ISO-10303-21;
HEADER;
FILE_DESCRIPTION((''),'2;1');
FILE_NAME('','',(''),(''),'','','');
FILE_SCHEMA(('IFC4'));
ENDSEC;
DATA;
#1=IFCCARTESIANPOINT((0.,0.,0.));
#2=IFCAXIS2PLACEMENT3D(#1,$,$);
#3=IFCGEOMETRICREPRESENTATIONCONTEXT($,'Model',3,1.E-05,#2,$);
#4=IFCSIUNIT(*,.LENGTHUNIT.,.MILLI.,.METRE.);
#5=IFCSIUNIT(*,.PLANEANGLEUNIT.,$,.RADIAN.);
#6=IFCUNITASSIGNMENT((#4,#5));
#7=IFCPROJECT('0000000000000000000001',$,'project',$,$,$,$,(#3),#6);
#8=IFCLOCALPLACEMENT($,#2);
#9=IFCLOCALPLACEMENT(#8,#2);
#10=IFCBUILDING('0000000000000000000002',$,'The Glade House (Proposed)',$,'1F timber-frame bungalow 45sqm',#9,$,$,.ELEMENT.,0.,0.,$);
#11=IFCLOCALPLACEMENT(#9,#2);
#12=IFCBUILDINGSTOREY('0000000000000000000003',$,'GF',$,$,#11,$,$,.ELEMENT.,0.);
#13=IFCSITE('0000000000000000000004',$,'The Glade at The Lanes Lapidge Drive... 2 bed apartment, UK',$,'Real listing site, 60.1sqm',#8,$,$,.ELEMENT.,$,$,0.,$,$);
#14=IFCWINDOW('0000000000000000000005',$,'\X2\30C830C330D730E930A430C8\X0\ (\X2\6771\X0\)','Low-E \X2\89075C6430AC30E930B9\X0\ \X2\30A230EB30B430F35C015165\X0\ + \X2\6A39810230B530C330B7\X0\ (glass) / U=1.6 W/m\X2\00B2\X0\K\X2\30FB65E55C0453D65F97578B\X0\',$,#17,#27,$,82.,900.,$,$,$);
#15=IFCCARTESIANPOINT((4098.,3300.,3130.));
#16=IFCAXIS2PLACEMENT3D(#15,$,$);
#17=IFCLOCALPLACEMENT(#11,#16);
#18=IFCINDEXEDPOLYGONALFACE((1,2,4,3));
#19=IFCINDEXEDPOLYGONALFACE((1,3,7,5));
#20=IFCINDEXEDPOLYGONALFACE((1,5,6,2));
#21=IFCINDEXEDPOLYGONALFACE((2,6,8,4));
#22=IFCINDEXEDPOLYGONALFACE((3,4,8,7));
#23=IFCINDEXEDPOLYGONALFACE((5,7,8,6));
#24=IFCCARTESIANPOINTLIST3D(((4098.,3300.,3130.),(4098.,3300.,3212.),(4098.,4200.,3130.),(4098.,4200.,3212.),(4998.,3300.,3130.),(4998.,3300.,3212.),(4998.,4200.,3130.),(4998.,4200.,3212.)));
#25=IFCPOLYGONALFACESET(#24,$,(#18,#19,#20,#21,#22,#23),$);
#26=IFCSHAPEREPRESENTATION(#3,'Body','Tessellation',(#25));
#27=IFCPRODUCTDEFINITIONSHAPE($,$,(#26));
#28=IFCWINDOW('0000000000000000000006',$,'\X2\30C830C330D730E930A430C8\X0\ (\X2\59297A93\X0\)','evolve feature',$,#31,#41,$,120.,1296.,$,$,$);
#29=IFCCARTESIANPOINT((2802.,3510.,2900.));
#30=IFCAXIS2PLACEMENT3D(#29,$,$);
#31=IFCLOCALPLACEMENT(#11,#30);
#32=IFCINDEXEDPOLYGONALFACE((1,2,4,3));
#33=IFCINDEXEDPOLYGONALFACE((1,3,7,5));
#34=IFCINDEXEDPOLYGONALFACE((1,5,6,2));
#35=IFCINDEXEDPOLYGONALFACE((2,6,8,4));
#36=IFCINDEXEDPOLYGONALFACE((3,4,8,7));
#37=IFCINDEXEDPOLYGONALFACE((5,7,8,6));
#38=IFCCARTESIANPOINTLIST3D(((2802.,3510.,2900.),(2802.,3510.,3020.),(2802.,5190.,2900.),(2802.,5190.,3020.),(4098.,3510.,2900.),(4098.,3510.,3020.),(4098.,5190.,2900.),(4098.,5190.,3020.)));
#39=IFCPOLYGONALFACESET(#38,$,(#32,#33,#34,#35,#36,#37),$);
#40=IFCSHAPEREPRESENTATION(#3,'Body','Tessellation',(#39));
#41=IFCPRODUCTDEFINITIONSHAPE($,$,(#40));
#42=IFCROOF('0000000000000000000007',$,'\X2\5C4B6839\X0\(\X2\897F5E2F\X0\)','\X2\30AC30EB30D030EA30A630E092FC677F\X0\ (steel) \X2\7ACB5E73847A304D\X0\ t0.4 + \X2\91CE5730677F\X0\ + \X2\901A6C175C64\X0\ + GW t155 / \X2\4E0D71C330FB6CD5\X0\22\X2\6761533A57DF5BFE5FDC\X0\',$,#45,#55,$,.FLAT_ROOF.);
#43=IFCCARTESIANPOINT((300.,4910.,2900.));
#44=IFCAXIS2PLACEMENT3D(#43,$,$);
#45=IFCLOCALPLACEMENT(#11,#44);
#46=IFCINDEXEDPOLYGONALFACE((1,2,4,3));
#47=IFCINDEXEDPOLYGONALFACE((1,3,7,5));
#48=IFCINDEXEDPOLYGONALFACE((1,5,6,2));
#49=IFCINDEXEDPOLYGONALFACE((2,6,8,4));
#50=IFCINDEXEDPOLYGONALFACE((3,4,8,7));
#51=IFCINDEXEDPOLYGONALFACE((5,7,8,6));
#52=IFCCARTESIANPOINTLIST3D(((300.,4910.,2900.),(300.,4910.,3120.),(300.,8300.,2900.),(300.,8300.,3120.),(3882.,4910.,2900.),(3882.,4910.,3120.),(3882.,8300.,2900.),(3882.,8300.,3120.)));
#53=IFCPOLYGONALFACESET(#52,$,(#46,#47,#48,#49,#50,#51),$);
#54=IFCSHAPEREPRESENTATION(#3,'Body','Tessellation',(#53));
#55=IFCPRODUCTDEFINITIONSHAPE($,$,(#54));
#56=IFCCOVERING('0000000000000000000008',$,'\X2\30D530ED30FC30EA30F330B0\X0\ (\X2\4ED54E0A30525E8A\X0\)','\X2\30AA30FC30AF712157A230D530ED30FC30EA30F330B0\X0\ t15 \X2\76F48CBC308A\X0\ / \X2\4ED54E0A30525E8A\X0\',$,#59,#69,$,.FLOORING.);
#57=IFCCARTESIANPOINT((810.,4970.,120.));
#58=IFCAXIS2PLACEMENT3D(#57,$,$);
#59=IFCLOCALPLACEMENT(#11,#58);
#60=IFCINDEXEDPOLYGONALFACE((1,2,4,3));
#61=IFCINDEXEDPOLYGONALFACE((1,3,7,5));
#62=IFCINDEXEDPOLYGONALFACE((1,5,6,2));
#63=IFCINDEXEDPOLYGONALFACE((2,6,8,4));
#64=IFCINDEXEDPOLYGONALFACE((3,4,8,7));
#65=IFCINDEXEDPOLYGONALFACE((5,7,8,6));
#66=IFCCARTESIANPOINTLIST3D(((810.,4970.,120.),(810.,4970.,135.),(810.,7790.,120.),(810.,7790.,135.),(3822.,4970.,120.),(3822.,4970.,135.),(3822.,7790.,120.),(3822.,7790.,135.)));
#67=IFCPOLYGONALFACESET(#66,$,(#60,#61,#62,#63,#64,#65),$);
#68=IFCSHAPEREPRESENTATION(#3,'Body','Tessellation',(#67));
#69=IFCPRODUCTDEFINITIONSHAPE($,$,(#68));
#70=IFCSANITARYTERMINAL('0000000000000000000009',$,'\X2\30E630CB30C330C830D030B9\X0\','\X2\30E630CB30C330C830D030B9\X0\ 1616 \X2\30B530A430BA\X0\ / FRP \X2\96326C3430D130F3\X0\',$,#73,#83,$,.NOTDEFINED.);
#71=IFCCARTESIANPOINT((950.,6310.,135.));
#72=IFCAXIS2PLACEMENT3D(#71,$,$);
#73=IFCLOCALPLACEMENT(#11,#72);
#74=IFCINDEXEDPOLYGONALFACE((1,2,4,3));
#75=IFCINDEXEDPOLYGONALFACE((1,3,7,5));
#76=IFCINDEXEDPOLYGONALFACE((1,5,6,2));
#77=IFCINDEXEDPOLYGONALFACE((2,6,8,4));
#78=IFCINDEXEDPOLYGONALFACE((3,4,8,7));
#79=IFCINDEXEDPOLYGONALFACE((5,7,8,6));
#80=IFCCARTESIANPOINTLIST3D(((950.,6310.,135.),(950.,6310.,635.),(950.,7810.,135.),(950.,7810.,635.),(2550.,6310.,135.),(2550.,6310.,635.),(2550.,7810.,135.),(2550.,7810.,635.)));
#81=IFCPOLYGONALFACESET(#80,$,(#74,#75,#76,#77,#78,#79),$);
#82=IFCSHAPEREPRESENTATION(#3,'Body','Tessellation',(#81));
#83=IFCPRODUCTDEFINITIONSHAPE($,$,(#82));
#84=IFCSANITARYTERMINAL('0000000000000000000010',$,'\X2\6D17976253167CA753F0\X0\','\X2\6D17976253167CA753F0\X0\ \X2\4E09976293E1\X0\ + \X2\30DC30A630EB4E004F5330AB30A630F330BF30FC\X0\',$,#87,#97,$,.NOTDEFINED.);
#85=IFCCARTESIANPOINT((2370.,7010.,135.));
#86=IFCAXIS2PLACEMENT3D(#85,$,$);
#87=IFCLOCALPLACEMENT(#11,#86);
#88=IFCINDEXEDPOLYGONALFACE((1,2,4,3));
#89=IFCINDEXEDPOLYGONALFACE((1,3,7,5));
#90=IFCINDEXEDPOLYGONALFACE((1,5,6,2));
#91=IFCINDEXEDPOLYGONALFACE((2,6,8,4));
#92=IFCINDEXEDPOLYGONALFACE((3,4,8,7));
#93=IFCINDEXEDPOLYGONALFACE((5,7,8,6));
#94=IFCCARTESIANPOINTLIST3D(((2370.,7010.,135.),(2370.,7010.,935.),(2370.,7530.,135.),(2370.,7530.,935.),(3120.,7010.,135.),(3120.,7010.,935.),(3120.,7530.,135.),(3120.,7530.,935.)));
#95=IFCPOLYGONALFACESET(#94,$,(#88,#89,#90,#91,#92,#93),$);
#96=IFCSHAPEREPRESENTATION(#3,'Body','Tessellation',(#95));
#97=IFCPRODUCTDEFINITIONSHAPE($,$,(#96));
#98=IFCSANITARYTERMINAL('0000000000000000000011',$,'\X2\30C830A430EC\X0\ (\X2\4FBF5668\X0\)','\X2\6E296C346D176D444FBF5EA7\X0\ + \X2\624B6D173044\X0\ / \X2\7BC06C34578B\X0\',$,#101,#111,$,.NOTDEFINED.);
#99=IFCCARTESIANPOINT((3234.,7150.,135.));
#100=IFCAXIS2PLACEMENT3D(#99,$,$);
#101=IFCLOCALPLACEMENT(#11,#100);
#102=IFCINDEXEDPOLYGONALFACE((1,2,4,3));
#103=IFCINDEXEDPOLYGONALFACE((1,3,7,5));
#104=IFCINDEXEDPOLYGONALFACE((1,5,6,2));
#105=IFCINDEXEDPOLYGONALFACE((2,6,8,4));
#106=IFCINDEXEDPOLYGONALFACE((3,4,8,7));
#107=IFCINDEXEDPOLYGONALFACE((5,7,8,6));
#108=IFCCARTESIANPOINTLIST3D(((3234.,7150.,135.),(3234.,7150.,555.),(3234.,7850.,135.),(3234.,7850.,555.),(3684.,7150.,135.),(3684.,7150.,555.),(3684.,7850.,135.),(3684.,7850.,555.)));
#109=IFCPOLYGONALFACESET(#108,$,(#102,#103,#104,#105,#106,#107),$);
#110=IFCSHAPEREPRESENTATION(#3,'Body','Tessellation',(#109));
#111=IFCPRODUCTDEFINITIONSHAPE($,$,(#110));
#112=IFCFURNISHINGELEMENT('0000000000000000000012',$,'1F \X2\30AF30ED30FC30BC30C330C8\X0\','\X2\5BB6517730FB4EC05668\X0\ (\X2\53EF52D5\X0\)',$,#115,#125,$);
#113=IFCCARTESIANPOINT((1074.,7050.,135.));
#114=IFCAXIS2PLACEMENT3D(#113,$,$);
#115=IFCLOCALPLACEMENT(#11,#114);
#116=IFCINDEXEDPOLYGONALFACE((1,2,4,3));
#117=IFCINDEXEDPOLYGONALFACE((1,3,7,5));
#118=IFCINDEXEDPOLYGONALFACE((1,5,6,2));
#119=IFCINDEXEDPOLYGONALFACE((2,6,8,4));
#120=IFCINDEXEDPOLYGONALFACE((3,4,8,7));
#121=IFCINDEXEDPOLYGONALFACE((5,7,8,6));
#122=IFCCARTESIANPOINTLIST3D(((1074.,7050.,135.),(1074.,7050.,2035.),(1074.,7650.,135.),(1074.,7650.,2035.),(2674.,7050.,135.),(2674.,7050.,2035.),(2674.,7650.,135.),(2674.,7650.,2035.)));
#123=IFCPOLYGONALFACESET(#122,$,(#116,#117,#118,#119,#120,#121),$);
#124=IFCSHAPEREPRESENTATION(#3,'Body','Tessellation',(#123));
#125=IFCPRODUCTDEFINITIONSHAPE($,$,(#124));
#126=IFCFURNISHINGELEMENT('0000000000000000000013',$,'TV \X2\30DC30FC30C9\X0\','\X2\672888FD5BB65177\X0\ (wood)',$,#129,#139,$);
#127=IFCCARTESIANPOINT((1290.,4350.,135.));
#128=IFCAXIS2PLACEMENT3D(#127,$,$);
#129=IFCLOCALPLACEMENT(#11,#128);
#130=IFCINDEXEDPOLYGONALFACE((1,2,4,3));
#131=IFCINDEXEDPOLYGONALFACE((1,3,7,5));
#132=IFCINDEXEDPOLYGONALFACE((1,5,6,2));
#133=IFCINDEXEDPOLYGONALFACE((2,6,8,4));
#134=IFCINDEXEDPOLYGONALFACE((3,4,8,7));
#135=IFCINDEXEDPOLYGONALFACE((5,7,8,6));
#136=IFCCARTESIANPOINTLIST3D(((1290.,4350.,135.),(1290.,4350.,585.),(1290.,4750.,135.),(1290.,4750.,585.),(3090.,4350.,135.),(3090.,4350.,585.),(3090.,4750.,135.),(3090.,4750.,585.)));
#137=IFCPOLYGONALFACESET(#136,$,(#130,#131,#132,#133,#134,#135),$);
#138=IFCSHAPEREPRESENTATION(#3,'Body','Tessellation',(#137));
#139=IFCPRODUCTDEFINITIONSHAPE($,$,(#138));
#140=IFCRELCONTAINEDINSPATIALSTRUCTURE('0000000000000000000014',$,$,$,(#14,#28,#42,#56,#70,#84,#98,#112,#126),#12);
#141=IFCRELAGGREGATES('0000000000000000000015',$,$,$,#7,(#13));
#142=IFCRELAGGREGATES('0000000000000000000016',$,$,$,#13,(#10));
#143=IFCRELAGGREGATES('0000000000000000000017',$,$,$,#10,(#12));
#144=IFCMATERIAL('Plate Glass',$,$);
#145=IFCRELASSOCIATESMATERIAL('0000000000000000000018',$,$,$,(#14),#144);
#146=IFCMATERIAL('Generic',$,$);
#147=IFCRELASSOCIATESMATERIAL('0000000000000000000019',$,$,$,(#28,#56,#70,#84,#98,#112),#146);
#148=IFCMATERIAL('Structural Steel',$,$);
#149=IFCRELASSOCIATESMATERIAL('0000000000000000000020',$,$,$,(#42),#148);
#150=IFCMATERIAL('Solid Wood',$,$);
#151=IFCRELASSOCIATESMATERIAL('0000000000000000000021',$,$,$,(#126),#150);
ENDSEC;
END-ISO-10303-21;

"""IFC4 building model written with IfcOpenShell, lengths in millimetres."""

from ifc_helpers import new_model, si_unit, frame, frame_2d, origin, place, context, project, spatial, rectangle, extrude, material, element, save


model = new_model("IFC4")

# Units and contexts
model_context = context("Model", 3, precision=1e-05, world=origin())
ifc_project = project(units=[si_unit("LENGTHUNIT", "METRE", prefix="MILLI"), si_unit("PLANEANGLEUNIT", "RADIAN")], contexts=[model_context])

# Site, building, storey
site_placement = place(None, origin())
site = spatial("IfcSite", under=ifc_project, at=site_placement, Name="The Glade at The Lanes Lapidge Drive... 2 bed apartment, UK", ObjectType="Real listing site, 60.1sqm", CompositionType="ELEMENT", RefElevation=0.0)
building_placement = place(site_placement, origin())
building = spatial("IfcBuilding", under=site, at=building_placement, Name="The Glade House (Proposed)", ObjectType="1F timber-frame bungalow 45sqm", CompositionType="ELEMENT", ElevationOfRefHeight=0.0, ElevationOfTerrain=0.0)
storey_placement = place(building_placement, origin())
storey = spatial("IfcBuildingStorey", under=building, at=storey_placement, Name="GF", CompositionType="ELEMENT", Elevation=0.0)

# Shared definitions
ifc_material_1 = material(Name="Solid Wood")

# Shared definitions
ifc_material_2 = material(Name="Plate Glass")

# Windows
window_1_placement = place(storey_placement, frame((4098.0, 3300.0, 3130.0)))
element("IfcWindow", 1, at=window_1_placement, inside=storey, material=ifc_material_2, Name="トップライト (東)", Description="Low-E 複層ガラス アルゴン封入 + 樹脂サッシ (glass) / U=1.6 W/m²K・日射取得型", OverallHeight=82.0, OverallWidth=900.0, context=model_context, shape_type="SweptSolid", body=[
    extrude(rectangle(XDim=900.0, YDim=900.0, at=frame_2d((450.0, 450.0))), frame((4098.0, 3300.0, 3130.0)), (0.0, 0.0, 1.0), 82.0),
])
ifc_material_3 = material(Name="Generic")
window_2_placement = place(storey_placement, frame((2802.0, 3510.0, 2900.0)))
element("IfcWindow", 2, at=window_2_placement, inside=storey, material=ifc_material_3, Name="トップライト (天窓)", Description="evolve feature", OverallHeight=120.0, OverallWidth=1296.0, context=model_context, shape_type="SweptSolid", body=[
    extrude(rectangle(XDim=1296.0, YDim=1680.0, at=frame_2d((648.0, 840.0))), frame((2802.0, 3510.0, 2900.0)), (0.0, 0.0, 1.0), 120.0),
])

# Roof
ifc_material_4 = material(Name="Structural Steel")
roof_placement = place(storey_placement, frame((300.0, 4910.0, 2900.0)))
element("IfcRoof", 3, at=roof_placement, inside=storey, material=ifc_material_4, Name="屋根(西帯)", Description="ガルバリウム鋼板 (steel) 立平葺き t0.4 + 野地板 + 通気層 + GW t155 / 不燃・法22条区域対応", PredefinedType="FLAT_ROOF", context=model_context, shape_type="SweptSolid", body=[
    extrude(rectangle(XDim=3582.0, YDim=3390.0, at=frame_2d((1791.0, 1695.0))), frame((300.0, 4910.0, 2900.0)), (0.0, 0.0, 1.0), 220.0),
])

# Covering
covering_placement = place(storey_placement, frame((810.0, 4970.0, 120.0)))
element("IfcCovering", 4, at=covering_placement, inside=storey, material=ifc_material_3, Name="フローリング (仕上げ床)", Description="オーク無垢フローリング t15 直貼り / 仕上げ床", PredefinedType="FLOORING", context=model_context, shape_type="SweptSolid", body=[
    extrude(rectangle(XDim=3012.0, YDim=2820.0, at=frame_2d((1506.0, 1410.0))), frame((810.0, 4970.0, 120.0)), (0.0, 0.0, 1.0), 15.0),
])

# Sanitary terminals
sanitary_terminal_1_placement = place(storey_placement, frame((950.0, 6310.0, 135.0)))
element("IfcSanitaryTerminal", 5, at=sanitary_terminal_1_placement, inside=storey, material=ifc_material_3, Name="ユニットバス", Description="ユニットバス 1616 サイズ / FRP 防水パン", PredefinedType="NOTDEFINED", context=model_context, shape_type="SweptSolid", body=[
    extrude(rectangle(XDim=1600.0, YDim=1500.0, at=frame_2d((800.0, 750.0))), frame((950.0, 6310.0, 135.0)), (0.0, 0.0, 1.0), 500.0),
])
sanitary_terminal_2_placement = place(storey_placement, frame((2370.0, 7010.0, 135.0)))
element("IfcSanitaryTerminal", 6, at=sanitary_terminal_2_placement, inside=storey, material=ifc_material_3, Name="洗面化粧台", Description="洗面化粧台 三面鏡 + ボウル一体カウンター", PredefinedType="NOTDEFINED", context=model_context, shape_type="SweptSolid", body=[
    extrude(rectangle(XDim=750.0, YDim=520.0, at=frame_2d((375.0, 260.0))), frame((2370.0, 7010.0, 135.0)), (0.0, 0.0, 1.0), 800.0),
])
sanitary_terminal_3_placement = place(storey_placement, frame((3234.0, 7150.0, 135.0)))
element("IfcSanitaryTerminal", 7, at=sanitary_terminal_3_placement, inside=storey, material=ifc_material_3, Name="トイレ (便器)", Description="温水洗浄便座 + 手洗い / 節水型", PredefinedType="NOTDEFINED", context=model_context, shape_type="SweptSolid", body=[
    extrude(rectangle(XDim=450.0, YDim=700.0, at=frame_2d((225.0, 350.0))), frame((3234.0, 7150.0, 135.0)), (0.0, 0.0, 1.0), 420.0),
])

# Furnishing elements
furnishing_1_placement = place(storey_placement, frame((1074.0, 7050.0, 135.0)))
element("IfcFurnishingElement", 8, at=furnishing_1_placement, inside=storey, material=ifc_material_3, Name="1F クローゼット", Description="家具・什器 (可動)", context=model_context, shape_type="SweptSolid", body=[
    extrude(rectangle(XDim=1600.0, YDim=600.0, at=frame_2d((800.0, 300.0))), frame((1074.0, 7050.0, 135.0)), (0.0, 0.0, 1.0), 1900.0),
])
furnishing_2_placement = place(storey_placement, frame((1290.0, 4350.0, 135.0)))
element("IfcFurnishingElement", 9, at=furnishing_2_placement, inside=storey, material=ifc_material_1, Name="TV ボード", Description="木製家具 (wood)", context=model_context, shape_type="SweptSolid", body=[
    extrude(rectangle(XDim=1800.0, YDim=400.0, at=frame_2d((900.0, 200.0))), frame((1290.0, 4350.0, 135.0)), (0.0, 0.0, 1.0), 450.0),
])

save(model, "model.ifc")
